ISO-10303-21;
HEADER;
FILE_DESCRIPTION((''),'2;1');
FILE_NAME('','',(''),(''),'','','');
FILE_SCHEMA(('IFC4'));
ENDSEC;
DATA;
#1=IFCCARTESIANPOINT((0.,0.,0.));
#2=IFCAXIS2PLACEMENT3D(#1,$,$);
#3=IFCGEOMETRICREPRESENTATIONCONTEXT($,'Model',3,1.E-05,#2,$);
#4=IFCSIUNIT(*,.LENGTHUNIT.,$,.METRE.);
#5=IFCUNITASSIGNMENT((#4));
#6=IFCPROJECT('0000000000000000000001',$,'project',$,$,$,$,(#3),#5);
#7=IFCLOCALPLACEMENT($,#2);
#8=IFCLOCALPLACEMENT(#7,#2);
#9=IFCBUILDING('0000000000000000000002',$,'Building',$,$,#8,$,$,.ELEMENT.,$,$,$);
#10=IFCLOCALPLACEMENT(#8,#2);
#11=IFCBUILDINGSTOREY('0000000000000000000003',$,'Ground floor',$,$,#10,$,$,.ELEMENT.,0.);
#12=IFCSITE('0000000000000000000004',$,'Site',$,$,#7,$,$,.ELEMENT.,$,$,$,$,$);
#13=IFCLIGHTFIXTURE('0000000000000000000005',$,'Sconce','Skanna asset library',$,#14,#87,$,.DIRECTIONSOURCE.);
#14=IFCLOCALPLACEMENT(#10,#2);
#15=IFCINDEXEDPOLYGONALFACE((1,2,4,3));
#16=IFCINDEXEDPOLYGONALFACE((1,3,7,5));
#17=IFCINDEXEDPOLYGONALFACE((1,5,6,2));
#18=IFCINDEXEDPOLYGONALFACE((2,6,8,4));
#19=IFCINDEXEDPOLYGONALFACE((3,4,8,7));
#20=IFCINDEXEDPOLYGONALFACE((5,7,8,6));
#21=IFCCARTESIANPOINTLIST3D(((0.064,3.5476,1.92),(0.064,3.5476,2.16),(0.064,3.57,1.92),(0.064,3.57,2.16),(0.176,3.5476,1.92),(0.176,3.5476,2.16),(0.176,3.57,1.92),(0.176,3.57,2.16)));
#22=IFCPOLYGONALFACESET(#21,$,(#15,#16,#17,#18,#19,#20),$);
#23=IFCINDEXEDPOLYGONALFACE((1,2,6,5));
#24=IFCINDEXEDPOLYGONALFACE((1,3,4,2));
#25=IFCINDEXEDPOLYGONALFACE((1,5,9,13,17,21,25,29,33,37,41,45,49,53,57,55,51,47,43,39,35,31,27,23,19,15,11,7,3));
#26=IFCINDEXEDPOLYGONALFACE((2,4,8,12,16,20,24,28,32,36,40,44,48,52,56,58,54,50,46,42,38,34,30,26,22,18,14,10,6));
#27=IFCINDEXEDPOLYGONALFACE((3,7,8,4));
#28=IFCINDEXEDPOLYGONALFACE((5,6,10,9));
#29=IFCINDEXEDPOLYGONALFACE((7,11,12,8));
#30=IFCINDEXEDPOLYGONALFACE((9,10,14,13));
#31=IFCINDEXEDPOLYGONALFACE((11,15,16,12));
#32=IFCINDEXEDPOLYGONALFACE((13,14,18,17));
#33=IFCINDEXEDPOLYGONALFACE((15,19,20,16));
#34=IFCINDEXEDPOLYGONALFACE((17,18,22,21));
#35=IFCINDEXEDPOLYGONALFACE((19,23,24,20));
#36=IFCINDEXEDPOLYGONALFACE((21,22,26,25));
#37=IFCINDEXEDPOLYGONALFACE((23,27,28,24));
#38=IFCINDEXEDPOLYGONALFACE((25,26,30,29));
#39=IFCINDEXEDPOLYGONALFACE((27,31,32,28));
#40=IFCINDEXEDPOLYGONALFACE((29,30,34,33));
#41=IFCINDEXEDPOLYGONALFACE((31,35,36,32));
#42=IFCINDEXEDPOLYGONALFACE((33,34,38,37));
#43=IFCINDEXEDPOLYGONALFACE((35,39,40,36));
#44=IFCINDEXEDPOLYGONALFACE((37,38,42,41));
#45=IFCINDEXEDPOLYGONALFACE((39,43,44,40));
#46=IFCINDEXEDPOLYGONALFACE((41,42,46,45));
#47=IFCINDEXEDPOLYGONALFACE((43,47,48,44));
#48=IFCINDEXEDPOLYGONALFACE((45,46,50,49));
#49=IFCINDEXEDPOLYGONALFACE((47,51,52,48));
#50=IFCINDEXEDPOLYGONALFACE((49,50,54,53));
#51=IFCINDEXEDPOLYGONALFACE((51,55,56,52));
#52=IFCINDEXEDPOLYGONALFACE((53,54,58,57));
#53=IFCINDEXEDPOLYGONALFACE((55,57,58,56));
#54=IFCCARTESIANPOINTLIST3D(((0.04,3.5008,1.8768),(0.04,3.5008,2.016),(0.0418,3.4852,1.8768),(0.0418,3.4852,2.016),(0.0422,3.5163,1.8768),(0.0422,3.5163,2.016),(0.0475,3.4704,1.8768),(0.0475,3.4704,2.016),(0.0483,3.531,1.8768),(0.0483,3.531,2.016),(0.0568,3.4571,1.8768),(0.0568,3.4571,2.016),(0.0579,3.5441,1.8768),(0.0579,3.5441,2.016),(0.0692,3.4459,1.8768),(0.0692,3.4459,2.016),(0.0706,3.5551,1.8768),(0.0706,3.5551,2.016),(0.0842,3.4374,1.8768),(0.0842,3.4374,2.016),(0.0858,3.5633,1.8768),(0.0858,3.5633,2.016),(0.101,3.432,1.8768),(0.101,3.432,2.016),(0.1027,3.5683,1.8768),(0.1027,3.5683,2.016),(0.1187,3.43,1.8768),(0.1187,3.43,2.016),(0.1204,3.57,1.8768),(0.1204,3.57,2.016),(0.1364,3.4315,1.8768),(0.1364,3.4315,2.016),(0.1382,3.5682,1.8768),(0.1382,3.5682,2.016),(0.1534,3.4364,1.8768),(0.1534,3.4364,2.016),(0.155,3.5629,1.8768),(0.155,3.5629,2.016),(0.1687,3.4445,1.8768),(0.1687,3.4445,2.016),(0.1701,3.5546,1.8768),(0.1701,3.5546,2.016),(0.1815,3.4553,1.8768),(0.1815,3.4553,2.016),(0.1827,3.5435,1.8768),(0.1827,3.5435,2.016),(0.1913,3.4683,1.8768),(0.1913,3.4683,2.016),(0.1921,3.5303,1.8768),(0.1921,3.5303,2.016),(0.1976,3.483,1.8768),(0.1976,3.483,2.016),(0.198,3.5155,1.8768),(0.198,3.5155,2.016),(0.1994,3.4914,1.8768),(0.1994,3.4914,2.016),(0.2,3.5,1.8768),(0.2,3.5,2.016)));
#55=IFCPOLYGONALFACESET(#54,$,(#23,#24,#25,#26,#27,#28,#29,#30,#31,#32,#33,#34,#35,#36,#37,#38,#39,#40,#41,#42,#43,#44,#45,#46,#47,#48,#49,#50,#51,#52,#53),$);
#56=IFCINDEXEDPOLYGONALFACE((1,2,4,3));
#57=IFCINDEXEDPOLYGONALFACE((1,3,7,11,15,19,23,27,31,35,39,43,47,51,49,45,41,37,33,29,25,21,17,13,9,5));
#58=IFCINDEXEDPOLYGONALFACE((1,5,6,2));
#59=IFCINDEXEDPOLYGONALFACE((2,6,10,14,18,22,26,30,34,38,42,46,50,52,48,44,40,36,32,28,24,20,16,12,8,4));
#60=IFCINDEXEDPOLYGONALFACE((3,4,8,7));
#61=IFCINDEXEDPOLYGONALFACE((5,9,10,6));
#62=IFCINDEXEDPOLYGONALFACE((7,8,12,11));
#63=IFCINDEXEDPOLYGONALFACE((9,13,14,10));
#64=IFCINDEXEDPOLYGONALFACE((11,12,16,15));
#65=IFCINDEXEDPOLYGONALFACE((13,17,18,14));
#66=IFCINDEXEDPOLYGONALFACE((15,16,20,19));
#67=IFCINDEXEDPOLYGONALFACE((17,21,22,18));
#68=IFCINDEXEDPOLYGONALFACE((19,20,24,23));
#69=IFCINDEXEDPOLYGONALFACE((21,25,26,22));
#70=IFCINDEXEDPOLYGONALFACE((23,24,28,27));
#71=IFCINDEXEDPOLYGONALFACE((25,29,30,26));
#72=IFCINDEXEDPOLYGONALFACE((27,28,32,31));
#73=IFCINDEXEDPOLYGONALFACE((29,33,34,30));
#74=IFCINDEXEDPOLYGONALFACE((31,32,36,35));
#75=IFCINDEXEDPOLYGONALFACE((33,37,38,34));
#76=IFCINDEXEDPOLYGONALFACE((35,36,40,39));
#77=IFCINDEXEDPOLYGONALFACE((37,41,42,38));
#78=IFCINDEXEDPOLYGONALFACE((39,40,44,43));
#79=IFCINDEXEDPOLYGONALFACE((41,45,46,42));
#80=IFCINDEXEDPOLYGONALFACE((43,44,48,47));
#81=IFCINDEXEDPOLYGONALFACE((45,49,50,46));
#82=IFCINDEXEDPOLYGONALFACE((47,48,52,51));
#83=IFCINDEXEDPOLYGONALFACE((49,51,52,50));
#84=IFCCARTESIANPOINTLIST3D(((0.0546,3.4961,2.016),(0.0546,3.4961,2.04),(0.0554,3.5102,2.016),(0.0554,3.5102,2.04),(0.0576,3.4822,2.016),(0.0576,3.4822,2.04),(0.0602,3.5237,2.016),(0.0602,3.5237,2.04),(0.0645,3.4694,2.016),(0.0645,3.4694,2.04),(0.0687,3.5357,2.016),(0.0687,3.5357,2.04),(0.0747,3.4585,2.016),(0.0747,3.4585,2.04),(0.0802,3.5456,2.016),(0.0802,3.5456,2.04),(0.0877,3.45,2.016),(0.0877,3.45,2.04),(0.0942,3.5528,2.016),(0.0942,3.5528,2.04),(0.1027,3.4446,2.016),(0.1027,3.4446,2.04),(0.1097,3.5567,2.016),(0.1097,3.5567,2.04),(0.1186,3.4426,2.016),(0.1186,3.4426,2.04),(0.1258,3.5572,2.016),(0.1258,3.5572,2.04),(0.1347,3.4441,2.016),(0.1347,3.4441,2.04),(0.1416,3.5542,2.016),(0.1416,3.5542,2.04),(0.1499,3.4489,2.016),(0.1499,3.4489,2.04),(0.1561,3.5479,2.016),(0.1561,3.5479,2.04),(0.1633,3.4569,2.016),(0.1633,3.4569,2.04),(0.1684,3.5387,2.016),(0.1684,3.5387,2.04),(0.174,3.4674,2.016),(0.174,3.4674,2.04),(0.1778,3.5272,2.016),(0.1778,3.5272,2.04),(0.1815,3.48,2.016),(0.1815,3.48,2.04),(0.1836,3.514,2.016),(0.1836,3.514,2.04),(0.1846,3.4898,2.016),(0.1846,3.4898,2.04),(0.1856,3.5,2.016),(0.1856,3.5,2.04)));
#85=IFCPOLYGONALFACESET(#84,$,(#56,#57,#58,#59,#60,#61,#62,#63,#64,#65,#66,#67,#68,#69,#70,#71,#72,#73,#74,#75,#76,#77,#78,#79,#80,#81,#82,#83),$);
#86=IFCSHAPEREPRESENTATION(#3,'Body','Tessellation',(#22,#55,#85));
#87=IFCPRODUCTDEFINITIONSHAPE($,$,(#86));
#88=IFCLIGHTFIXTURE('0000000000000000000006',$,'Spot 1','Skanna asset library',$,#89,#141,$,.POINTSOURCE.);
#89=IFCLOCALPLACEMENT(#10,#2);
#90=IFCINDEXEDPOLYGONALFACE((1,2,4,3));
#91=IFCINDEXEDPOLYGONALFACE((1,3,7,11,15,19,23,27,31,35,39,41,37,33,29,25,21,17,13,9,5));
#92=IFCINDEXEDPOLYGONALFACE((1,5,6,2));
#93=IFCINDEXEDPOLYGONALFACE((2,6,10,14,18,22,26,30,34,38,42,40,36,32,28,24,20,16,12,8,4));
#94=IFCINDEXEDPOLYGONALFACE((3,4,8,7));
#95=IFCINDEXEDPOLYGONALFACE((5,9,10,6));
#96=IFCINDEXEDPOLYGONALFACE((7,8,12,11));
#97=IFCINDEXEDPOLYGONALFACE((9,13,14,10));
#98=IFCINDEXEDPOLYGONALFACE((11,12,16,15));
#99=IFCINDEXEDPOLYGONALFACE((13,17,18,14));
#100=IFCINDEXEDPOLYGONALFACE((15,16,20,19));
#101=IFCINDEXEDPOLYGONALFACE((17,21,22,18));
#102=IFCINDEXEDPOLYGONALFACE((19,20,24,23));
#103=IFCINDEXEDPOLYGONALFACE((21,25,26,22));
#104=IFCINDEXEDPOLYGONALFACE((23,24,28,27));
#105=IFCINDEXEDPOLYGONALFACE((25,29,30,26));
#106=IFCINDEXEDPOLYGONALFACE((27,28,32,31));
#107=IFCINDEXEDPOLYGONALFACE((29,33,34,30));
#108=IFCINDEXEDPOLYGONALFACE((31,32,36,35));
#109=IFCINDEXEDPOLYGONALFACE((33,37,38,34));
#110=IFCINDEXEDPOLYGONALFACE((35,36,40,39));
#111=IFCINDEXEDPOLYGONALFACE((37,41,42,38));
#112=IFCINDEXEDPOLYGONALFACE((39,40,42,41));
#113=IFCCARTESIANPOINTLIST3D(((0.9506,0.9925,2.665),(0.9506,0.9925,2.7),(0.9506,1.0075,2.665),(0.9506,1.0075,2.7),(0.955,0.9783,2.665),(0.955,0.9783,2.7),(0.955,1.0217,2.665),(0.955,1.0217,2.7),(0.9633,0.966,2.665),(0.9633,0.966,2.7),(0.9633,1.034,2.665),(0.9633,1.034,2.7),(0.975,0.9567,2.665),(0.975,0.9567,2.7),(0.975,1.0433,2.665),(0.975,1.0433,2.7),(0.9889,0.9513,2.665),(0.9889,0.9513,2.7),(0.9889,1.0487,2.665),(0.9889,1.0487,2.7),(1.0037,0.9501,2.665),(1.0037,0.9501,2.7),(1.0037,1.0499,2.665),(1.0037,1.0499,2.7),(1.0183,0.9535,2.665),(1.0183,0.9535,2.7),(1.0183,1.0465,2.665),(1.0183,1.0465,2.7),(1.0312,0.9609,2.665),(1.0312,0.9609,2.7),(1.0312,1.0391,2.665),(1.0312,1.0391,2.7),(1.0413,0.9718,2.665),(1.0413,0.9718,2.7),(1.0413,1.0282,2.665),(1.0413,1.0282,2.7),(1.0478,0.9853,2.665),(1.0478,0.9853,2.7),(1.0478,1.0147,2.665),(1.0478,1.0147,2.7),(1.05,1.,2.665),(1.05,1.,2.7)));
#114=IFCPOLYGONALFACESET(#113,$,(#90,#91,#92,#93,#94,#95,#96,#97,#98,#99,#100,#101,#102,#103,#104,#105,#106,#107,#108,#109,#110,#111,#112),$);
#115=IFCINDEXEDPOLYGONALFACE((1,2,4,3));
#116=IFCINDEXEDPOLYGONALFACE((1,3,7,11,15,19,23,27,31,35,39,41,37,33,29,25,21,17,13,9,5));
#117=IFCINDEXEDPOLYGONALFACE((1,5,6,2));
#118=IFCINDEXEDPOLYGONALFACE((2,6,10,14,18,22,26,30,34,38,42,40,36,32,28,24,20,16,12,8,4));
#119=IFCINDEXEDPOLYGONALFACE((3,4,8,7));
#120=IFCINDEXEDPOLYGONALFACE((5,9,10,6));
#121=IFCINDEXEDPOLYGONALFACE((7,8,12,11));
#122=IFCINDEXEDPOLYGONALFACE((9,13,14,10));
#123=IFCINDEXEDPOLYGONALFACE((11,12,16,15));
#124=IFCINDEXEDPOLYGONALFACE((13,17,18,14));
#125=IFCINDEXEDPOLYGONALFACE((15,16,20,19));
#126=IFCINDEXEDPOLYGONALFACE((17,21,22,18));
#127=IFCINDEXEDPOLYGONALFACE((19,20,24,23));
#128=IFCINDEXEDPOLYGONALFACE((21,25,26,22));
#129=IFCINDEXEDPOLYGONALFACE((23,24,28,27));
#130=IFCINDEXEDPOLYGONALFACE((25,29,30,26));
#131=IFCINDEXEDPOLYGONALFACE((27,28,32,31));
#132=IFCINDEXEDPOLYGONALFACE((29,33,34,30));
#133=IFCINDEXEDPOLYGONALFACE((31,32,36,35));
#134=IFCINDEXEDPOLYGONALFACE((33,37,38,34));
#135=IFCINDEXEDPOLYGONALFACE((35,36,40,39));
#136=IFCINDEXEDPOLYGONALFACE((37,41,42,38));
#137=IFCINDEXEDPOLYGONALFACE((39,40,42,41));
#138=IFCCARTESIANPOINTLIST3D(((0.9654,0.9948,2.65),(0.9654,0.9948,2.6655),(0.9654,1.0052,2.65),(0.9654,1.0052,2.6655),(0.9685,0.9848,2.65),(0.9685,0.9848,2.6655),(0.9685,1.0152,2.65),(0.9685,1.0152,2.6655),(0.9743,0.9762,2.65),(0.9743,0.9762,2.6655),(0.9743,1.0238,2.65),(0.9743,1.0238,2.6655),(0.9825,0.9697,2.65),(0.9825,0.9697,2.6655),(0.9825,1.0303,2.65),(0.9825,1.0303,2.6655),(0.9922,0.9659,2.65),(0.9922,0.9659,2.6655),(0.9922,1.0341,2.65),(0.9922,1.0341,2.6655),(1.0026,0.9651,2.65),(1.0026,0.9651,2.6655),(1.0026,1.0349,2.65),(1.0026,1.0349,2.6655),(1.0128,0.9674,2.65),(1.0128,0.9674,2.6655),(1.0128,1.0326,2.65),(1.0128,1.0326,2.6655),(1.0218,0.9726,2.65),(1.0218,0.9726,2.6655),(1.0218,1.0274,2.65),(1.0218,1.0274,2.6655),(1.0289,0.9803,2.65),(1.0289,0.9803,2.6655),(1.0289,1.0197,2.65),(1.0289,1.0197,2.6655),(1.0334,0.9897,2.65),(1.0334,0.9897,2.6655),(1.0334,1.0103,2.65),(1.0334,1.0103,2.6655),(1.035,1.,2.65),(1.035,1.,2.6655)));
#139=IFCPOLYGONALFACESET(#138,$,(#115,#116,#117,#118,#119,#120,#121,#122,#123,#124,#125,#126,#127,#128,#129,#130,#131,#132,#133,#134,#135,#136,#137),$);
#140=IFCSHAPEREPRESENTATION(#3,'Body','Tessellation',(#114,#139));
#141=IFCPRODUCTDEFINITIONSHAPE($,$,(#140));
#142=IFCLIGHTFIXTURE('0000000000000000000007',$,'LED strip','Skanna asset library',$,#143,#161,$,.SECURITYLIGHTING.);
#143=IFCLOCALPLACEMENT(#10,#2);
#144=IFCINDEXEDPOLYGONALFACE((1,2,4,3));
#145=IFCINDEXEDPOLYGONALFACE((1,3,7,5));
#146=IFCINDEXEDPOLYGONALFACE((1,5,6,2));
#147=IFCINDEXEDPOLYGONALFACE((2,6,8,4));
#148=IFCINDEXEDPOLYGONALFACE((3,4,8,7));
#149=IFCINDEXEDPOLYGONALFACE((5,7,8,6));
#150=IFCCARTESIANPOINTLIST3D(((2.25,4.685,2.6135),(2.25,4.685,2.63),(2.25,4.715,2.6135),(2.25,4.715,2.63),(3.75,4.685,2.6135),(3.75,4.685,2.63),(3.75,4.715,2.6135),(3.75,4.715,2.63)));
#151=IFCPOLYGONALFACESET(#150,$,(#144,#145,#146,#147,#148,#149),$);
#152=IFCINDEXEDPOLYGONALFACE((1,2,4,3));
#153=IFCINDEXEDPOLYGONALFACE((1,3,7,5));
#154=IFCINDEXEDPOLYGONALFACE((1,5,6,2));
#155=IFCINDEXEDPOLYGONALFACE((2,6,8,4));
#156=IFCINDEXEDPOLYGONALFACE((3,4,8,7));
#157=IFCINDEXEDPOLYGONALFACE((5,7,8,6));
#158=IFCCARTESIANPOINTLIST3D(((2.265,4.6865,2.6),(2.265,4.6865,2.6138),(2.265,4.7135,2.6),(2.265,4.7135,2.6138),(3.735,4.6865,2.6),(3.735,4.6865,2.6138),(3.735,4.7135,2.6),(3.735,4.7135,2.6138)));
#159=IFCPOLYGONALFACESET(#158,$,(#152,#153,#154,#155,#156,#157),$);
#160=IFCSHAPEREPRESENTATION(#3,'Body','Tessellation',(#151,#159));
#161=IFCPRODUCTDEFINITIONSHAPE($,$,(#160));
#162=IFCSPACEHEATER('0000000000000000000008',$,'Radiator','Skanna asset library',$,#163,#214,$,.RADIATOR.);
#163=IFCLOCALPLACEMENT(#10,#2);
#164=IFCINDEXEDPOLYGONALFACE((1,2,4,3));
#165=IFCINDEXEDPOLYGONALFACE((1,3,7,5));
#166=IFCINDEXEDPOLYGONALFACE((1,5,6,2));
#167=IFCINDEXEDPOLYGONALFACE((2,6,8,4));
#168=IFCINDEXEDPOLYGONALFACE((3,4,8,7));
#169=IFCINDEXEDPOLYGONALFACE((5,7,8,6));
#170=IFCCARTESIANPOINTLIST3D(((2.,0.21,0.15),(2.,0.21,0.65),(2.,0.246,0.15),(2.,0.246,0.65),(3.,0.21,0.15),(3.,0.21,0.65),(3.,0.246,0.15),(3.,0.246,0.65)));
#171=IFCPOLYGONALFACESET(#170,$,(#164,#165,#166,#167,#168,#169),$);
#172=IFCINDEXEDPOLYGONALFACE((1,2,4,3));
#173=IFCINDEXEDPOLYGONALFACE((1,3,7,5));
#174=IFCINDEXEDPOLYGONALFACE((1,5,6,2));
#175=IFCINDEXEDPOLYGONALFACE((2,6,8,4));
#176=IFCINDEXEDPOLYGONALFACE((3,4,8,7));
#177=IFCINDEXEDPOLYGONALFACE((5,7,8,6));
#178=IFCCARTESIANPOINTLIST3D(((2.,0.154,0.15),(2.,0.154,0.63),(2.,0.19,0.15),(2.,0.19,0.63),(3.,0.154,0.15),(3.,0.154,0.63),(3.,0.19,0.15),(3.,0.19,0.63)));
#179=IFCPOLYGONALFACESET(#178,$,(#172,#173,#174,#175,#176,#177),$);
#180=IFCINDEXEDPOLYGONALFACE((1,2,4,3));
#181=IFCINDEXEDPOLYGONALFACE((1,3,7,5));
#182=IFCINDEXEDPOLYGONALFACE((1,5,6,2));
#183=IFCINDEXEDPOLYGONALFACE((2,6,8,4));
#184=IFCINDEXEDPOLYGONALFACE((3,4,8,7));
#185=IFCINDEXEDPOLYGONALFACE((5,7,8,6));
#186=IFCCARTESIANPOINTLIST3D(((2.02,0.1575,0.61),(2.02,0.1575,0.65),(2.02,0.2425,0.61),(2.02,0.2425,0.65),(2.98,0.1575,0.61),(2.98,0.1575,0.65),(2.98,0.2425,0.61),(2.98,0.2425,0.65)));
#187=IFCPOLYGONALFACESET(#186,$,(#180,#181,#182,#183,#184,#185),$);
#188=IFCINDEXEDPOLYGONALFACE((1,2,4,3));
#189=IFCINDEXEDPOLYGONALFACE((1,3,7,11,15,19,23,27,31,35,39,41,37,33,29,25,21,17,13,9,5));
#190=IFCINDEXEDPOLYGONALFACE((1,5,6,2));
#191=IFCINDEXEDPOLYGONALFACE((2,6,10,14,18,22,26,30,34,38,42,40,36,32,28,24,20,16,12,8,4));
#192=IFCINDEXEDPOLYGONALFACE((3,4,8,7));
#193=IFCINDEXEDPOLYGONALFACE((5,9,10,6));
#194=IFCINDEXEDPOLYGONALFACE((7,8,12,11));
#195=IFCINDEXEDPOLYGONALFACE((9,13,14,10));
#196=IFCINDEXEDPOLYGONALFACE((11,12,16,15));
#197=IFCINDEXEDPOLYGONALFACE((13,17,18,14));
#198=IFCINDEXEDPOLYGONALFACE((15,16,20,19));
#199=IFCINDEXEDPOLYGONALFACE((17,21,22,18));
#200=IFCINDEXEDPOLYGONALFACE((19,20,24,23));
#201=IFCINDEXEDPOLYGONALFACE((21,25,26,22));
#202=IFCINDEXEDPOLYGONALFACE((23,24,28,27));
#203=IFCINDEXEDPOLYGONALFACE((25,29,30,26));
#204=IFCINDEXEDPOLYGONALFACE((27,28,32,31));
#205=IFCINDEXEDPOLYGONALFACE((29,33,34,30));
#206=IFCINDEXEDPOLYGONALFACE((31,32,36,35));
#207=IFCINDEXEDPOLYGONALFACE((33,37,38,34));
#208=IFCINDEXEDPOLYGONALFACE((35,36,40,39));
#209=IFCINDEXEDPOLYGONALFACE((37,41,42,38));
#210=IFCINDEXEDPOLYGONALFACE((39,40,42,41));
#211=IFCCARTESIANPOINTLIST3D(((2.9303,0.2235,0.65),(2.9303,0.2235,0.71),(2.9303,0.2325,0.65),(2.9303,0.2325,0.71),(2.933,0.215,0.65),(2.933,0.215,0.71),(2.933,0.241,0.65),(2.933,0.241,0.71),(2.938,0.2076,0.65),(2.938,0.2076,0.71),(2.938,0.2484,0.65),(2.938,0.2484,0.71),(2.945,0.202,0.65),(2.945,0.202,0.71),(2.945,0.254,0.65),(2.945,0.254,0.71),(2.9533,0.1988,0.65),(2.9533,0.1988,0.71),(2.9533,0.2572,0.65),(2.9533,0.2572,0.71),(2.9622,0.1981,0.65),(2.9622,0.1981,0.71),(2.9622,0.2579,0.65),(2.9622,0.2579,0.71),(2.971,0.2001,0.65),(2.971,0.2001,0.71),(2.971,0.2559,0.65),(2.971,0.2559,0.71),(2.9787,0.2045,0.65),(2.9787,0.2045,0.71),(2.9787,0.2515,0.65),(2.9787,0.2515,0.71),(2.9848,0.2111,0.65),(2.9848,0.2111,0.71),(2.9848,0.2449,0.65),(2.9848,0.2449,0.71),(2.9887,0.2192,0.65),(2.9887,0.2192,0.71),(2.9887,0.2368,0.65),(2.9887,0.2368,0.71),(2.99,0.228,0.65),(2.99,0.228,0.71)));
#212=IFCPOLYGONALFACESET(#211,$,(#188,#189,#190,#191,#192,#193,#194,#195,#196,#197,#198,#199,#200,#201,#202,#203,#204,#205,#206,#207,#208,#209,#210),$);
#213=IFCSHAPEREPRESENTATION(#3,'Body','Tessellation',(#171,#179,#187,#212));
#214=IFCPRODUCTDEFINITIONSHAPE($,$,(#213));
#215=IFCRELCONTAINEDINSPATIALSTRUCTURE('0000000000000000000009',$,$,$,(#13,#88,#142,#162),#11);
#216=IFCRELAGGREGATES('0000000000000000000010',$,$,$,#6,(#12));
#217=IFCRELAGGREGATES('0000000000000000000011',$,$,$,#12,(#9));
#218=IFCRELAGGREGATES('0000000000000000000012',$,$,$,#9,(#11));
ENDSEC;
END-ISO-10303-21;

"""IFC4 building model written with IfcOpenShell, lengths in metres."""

from ifc_helpers import new_model, si_unit, frame, frame_2d, origin, origin_2d, place, context, project, spatial, rectangle, circle, ellipse, extrude, element, save


model = new_model("IFC4")

# Units and contexts
model_context = context("Model", 3, precision=1e-05, world=origin())
ifc_project = project(units=[si_unit("LENGTHUNIT", "METRE")], contexts=[model_context])

# Site, building, storey
site_placement = place(None, origin())
site = spatial("IfcSite", under=ifc_project, at=site_placement, Name="Site", CompositionType="ELEMENT")
building_placement = place(site_placement, origin())
building = spatial("IfcBuilding", under=site, at=building_placement, Name="Building", CompositionType="ELEMENT")
storey_placement = place(building_placement, origin())
storey = spatial("IfcBuildingStorey", under=building, at=storey_placement, Name="Ground floor", CompositionType="ELEMENT", Elevation=0.0)

# Light fixtures
light_fixture_1_placement = place(storey_placement, frame((0.12, 3.5, 1.8), z_axis=(0.0, 0.0, 1.0), x_axis=(1.0, 0.0, 0.0)))
element("IfcLightFixture", 1, at=light_fixture_1_placement, inside=storey, Name="Sconce", Description="Skanna asset library", PredefinedType="DIRECTIONSOURCE", context=model_context, shape_type="SweptSolid", body=[
    extrude(rectangle(XDim=0.112, YDim=0.0224, at=frame_2d((0.0, 0.0588))), frame((0.0, 0.0, 0.12)), (0.0, 0.0, 1.0), 0.24),
    extrude(ellipse(SemiAxis1=0.08, SemiAxis2=0.07, at=origin_2d()), frame((0.0, 0.0, 0.0768)), (0.0, 0.0, 1.0), 0.1392),
    extrude(ellipse(SemiAxis1=0.0656, SemiAxis2=0.0574, at=origin_2d()), frame((0.0, 0.0, 0.216)), (0.0, 0.0, 1.0), 0.024),
])
light_fixture_2_placement = place(storey_placement, frame((1.0, 1.0, 2.65), z_axis=(0.0, 0.0, 1.0), x_axis=(1.0, 0.0, 0.0)))
element("IfcLightFixture", 2, at=light_fixture_2_placement, inside=storey, Name="Spot 1", Description="Skanna asset library", PredefinedType="POINTSOURCE", context=model_context, shape_type="SweptSolid", body=[
    extrude(circle(Radius=0.05, at=origin_2d()), frame((0.0, 0.0, 0.015)), (0.0, 0.0, 1.0), 0.035),
    extrude(circle(Radius=0.035, at=origin_2d()), origin(), (0.0, 0.0, 1.0), 0.0155),
])
light_fixture_3_placement = place(storey_placement, frame((3.0, 4.7, 2.6), z_axis=(0.0, 0.0, 1.0), x_axis=(1.0, 0.0, 0.0)))
element("IfcLightFixture", 3, at=light_fixture_3_placement, inside=storey, Name="LED strip", Description="Skanna asset library", PredefinedType="SECURITYLIGHTING", context=model_context, shape_type="SweptSolid", body=[
    extrude(rectangle(XDim=1.5, YDim=0.03, at=origin_2d()), frame((0.0, 0.0, 0.0135)), (0.0, 0.0, 1.0), 0.0165),
    extrude(rectangle(XDim=1.47, YDim=0.027, at=origin_2d()), origin(), (0.0, 0.0, 1.0), 0.0138),
])

# Space heater
space_heater_placement = place(storey_placement, frame((2.5, 0.2, 0.15), z_axis=(0.0, 0.0, 1.0), x_axis=(1.0, 0.0, 0.0)))
element("IfcSpaceHeater", 4, at=space_heater_placement, inside=storey, Name="Radiator", Description="Skanna asset library", PredefinedType="RADIATOR", context=model_context, shape_type="SweptSolid", body=[
    extrude(rectangle(XDim=1.0, YDim=0.036, at=frame_2d((0.0, 0.028))), origin(), (0.0, 0.0, 1.0), 0.5),
    extrude(rectangle(XDim=1.0, YDim=0.036, at=frame_2d((0.0, -0.028))), origin(), (0.0, 0.0, 1.0), 0.48),
    extrude(rectangle(XDim=0.96, YDim=0.085, at=origin_2d()), frame((0.0, 0.0, 0.46)), (0.0, 0.0, 1.0), 0.04),
    extrude(circle(Radius=0.03, at=frame_2d((0.46, 0.028))), frame((0.0, 0.0, 0.5)), (0.0, 0.0, 1.0), 0.06),
])

save(model, "model.ifc")
